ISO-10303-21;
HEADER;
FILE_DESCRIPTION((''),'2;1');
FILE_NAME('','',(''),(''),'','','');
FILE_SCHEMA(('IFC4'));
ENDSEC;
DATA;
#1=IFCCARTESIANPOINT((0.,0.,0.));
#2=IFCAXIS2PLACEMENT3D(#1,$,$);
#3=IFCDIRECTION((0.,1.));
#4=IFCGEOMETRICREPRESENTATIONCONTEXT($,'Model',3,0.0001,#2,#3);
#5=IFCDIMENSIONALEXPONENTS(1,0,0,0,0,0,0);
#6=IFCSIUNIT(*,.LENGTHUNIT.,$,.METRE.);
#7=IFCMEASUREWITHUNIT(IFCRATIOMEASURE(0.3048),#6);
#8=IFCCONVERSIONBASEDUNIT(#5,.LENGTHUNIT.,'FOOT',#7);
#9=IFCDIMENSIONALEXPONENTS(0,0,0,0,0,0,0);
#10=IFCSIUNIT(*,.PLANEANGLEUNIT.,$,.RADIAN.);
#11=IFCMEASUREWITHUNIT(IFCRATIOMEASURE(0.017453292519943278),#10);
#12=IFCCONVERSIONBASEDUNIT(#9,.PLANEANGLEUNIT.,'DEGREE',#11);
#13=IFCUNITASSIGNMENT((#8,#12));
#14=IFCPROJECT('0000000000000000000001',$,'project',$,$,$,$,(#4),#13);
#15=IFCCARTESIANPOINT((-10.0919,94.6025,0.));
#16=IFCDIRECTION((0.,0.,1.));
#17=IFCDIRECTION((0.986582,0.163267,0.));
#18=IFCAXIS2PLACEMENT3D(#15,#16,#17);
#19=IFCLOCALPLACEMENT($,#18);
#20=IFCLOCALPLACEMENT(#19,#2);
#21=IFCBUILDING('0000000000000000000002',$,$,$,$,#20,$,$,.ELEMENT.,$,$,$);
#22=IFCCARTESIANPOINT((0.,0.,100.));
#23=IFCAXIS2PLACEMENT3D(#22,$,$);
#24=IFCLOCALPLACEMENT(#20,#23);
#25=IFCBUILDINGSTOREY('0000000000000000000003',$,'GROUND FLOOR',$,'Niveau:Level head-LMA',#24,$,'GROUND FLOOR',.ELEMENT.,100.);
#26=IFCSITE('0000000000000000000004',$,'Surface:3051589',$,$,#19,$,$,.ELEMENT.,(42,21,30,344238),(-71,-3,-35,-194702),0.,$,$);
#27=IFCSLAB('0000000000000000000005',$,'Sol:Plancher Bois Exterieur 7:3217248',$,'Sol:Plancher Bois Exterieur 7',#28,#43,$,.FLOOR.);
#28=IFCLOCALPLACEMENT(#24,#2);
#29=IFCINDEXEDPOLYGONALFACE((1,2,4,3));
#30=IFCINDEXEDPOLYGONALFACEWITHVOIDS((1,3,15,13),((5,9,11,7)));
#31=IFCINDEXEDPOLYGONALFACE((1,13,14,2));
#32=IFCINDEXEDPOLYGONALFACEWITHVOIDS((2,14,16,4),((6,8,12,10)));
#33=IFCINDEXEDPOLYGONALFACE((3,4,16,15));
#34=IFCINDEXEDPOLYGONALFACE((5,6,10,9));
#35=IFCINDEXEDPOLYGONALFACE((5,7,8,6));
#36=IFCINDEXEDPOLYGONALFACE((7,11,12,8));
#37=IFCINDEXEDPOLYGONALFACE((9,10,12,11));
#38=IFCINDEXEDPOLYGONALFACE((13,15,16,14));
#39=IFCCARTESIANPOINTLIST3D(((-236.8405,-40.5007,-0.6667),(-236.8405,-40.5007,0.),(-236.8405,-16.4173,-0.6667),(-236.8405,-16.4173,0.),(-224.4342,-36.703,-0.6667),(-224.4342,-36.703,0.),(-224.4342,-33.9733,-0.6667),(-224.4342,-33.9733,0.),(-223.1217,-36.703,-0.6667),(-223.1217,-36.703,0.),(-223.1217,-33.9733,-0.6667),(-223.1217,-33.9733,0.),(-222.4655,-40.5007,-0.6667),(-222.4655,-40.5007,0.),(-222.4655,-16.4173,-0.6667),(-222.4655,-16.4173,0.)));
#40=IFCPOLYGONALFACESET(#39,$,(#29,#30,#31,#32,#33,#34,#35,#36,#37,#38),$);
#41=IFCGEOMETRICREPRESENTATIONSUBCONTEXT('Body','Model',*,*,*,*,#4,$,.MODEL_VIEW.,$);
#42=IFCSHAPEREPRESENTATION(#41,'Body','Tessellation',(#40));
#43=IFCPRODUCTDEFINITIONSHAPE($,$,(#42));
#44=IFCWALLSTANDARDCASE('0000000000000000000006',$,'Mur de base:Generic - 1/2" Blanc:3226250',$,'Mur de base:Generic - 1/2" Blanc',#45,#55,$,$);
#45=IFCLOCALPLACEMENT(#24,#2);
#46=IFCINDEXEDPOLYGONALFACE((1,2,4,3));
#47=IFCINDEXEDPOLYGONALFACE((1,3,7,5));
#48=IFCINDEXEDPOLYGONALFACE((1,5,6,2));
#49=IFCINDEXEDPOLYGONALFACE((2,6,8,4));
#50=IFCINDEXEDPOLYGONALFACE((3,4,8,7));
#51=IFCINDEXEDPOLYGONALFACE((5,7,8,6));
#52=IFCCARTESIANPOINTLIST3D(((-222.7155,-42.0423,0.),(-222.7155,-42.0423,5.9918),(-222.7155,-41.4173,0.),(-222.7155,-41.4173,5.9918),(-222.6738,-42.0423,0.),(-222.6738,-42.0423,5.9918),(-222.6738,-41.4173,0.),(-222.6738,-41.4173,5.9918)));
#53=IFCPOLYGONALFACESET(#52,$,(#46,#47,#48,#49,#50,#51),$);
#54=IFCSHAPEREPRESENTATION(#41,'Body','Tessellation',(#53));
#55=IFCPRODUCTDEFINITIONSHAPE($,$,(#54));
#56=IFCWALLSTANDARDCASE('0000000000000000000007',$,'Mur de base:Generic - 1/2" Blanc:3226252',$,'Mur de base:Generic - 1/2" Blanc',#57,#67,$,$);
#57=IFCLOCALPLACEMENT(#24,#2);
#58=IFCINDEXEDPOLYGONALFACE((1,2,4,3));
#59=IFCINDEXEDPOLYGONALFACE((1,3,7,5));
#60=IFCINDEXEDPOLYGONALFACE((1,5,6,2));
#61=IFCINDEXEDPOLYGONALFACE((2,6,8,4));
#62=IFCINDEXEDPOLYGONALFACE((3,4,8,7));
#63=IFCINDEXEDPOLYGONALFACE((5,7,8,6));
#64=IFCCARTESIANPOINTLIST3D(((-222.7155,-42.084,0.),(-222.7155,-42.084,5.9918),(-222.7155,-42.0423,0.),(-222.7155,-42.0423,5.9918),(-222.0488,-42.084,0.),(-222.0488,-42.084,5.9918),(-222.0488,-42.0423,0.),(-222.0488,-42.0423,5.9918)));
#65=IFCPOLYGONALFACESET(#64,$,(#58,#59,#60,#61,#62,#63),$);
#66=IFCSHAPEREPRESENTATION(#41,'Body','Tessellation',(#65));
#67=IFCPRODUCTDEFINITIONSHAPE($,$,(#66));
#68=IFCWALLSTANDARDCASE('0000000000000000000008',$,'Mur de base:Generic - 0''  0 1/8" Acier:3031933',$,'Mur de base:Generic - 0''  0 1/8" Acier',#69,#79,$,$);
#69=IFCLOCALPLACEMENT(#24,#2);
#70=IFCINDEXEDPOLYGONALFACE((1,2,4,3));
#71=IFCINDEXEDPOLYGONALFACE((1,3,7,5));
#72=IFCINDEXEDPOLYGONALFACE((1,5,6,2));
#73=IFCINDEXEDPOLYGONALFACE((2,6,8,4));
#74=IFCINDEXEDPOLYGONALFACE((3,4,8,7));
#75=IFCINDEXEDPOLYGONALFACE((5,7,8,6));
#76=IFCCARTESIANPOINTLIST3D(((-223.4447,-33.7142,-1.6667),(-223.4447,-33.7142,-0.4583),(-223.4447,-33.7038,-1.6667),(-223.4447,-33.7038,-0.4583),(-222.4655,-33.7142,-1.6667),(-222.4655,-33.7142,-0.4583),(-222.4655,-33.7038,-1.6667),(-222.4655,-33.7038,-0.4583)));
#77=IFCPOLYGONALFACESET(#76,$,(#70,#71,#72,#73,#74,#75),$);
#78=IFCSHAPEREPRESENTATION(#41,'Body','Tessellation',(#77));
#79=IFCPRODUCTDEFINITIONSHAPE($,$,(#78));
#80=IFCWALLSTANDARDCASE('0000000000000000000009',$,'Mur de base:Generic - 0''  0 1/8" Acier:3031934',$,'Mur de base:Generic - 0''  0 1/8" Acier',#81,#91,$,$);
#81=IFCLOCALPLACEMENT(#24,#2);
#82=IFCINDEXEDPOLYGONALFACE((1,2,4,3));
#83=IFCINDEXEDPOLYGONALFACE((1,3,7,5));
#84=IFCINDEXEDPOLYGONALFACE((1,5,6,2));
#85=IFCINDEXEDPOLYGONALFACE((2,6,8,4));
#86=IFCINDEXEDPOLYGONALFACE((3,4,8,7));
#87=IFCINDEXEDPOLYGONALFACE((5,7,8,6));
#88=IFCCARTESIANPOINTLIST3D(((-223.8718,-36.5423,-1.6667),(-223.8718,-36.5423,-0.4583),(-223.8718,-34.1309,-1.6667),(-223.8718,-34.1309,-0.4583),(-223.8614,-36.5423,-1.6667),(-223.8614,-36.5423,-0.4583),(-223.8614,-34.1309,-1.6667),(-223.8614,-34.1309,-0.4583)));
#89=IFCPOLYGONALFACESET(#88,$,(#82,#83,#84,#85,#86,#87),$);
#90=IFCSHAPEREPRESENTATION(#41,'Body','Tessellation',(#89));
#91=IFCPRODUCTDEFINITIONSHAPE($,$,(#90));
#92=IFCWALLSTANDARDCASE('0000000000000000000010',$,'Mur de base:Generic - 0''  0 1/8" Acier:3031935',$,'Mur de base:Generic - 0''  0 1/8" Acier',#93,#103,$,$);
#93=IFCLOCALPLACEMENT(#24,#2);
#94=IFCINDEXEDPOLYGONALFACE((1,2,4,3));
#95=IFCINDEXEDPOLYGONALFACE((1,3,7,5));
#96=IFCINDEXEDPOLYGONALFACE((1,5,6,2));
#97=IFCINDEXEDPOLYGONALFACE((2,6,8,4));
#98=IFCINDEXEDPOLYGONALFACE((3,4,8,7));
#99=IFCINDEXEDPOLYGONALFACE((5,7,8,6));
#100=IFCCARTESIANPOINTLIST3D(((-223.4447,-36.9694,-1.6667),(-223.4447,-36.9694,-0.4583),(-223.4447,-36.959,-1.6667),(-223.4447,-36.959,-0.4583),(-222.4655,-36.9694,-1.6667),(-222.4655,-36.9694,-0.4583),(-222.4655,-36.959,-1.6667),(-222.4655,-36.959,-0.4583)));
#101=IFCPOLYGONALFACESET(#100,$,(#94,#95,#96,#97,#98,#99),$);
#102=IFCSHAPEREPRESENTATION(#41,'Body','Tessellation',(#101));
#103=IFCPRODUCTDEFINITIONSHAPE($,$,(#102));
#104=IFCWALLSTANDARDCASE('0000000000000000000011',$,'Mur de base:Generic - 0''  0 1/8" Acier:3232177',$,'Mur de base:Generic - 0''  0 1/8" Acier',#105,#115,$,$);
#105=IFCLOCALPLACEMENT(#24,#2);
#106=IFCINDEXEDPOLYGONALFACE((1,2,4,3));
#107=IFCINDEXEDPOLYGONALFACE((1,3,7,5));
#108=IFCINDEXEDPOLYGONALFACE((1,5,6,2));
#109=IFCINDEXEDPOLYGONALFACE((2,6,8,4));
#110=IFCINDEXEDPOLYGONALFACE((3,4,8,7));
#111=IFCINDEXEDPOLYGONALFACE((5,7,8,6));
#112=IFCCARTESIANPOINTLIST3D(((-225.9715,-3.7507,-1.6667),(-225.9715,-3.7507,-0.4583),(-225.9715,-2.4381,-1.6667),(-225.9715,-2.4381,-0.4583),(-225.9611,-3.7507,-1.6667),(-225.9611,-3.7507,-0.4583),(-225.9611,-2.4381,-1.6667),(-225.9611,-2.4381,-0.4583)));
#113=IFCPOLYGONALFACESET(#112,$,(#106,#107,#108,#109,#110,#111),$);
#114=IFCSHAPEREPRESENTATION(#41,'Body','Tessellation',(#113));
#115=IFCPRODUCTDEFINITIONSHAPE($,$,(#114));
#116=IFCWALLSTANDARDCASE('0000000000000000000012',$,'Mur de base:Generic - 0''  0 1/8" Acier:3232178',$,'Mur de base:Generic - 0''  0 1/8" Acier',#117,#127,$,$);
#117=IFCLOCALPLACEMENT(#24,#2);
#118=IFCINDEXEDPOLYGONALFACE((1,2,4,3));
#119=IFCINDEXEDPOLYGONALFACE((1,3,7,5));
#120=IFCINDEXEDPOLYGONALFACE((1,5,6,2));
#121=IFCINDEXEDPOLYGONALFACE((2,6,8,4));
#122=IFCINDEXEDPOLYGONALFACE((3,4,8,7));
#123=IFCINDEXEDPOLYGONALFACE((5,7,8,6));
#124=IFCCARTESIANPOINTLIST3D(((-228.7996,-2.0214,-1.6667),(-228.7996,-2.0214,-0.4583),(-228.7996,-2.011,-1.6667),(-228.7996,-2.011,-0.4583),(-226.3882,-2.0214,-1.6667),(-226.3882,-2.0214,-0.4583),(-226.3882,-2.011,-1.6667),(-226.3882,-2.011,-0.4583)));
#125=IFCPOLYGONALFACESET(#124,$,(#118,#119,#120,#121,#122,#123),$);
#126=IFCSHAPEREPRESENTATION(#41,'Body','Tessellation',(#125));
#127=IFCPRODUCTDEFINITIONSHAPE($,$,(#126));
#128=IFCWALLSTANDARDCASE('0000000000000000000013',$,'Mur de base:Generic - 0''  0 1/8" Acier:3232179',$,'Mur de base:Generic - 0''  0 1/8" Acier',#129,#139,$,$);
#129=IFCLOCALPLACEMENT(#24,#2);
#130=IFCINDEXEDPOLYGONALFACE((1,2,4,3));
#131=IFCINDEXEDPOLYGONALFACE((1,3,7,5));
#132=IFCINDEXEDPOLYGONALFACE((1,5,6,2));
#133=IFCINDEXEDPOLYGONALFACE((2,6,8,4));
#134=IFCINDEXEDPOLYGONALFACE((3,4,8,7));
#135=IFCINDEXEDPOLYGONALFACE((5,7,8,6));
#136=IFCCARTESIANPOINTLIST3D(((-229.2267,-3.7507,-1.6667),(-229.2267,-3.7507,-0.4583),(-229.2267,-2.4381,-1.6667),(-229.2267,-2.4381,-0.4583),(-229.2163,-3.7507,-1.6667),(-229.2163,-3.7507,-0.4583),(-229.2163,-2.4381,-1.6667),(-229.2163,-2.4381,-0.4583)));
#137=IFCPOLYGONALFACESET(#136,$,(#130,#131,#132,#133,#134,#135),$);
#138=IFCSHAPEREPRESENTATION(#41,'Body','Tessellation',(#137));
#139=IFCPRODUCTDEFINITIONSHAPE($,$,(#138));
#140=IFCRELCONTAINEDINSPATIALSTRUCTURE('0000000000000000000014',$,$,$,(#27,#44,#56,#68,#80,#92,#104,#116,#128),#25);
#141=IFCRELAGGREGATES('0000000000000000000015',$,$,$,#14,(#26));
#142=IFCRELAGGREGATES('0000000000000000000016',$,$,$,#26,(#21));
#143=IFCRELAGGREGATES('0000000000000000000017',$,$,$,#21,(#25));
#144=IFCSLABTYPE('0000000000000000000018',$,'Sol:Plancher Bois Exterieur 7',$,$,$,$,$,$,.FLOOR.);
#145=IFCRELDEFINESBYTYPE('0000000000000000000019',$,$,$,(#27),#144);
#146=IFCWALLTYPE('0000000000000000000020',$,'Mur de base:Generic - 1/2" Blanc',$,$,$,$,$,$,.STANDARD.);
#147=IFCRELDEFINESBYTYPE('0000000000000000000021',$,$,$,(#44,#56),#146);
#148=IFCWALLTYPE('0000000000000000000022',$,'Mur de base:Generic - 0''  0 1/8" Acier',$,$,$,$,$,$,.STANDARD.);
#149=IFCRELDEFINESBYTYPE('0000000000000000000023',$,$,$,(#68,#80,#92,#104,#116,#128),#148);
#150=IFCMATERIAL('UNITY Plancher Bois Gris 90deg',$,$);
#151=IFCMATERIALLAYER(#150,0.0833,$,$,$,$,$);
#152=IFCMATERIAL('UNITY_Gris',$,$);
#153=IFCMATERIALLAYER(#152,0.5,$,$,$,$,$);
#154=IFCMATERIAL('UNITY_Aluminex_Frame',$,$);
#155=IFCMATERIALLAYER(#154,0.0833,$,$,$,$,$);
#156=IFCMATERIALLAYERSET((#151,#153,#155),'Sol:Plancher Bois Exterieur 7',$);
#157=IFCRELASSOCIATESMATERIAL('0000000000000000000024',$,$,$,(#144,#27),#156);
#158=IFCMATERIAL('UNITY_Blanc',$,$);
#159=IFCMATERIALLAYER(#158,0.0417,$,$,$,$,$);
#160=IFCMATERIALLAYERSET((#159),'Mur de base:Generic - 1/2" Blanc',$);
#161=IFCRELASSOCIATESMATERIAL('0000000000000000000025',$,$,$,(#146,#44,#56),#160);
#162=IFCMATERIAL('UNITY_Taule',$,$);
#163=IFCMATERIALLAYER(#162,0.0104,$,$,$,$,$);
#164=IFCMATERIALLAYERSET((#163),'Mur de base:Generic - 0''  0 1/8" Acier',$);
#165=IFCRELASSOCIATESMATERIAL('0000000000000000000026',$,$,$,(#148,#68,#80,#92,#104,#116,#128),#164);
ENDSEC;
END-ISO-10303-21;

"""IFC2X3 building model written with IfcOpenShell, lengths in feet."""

from ifc_helpers import new_model, entity, si_unit, converted_unit, direction, frame, frame_2d, origin, origin_2d_with_axis, place, context, subcontext, project, spatial, polyline, rectangle, extrude, clip, bounded_halfspace, material, layer, layer_set, layer_usage, type_object, element, save


model = new_model("IFC2X3")

# Units and contexts
model_context = context("Model", 3, precision=0.0001, world=origin(), true_north=direction((0.0, 1.0)))
body_context = subcontext(model_context, "Body", "Model", "MODEL_VIEW")
ifc_project = project(units=[converted_unit("LENGTHUNIT", "FOOT", entity("IfcRatioMeasure", 0.3048), si_unit("LENGTHUNIT", "METRE"), dimensions=[1, 0, 0, 0, 0, 0, 0]), converted_unit("PLANEANGLEUNIT", "DEGREE", entity("IfcRatioMeasure", 0.017453292519943278), si_unit("PLANEANGLEUNIT", "RADIAN"), dimensions=[0, 0, 0, 0, 0, 0, 0])], contexts=[model_context])

# Site, building, storey
site_placement = place(None, frame((-10.0919, 94.6025, 0.0), z_axis=(0.0, 0.0, 1.0), x_axis=(0.986582, 0.163267, 0.0)))
site = spatial("IfcSite", under=ifc_project, at=site_placement, Name="Surface:3051589", CompositionType="ELEMENT", RefLatitude=(42, 21, 30, 344238), RefLongitude=(-71, -3, -35, -194702), RefElevation=0.0)
building_placement = place(site_placement, origin())
building = spatial("IfcBuilding", under=site, at=building_placement, CompositionType="ELEMENT")
storey_placement = place(building_placement, frame((0.0, 0.0, 100.0)))
storey = spatial("IfcBuildingStorey", under=building, at=storey_placement, Name="GROUND FLOOR", ObjectType="Niveau:Level head-LMA", LongName="GROUND FLOOR", CompositionType="ELEMENT", Elevation=100.0)

# Shared definitions
ifc_material_1 = material(Name="UNITY_Aluminex_Frame")

# Slab, opening
ifc_material_2 = material(Name="UNITY Plancher Bois Gris 90deg")
ifc_layer_1 = layer(ifc_material_2, 0.0833)
ifc_material_3 = material(Name="UNITY_Gris")
ifc_layer_2 = layer(ifc_material_3, 0.5)
ifc_layer_3 = layer(ifc_material_1, 0.0833)
ifc_layer_set_1 = layer_set([ifc_layer_1, ifc_layer_2, ifc_layer_3], Name="Sol:Plancher Bois Exterieur 7")
ifc_layer_usage_1 = layer_usage(ifc_layer_set_1, "AXIS3", "POSITIVE", 0.0)
slab_type = type_object("IfcSlabType", Name="Sol:Plancher Bois Exterieur 7", PredefinedType="FLOOR", material=ifc_layer_set_1)
slab_placement = place(storey_placement, frame((-236.8405, -40.5007, -0.6667)))
slab = element("IfcSlab", 1, at=slab_placement, inside=storey, type_object=slab_type, material=ifc_layer_usage_1, Name="Sol:Plancher Bois Exterieur 7:3217248", ObjectType="Sol:Plancher Bois Exterieur 7", PredefinedType="FLOOR", context=body_context, shape_type="SweptSolid", body=[
    extrude(rectangle(XDim=24.0833, YDim=14.375, at=frame_2d((0.0, 0.0), x_axis=(0.0, 1.0))), frame((7.1875, 12.0417, 0.6667), z_axis=(0.0, 0.0, -1.0), x_axis=(-1.0, 0.0, 0.0)), (0.0, 0.0, 1.0), 0.6667),
])
opening_1_placement = place(slab_placement, frame((13.0625, 5.1625, 0.6667)))
element("IfcOpeningElement", 2, at=opening_1_placement, cuts=slab, ObjectType="Opening", context=body_context, shape_type="SweptSolid", body=[
    extrude(rectangle(XDim=2.7297, YDim=1.3125, at=origin_2d_with_axis()), frame((0.0, 0.0, 0.0), z_axis=(0.0, 0.0, -1.0), x_axis=(0.0, 1.0, 0.0)), (0.0, 0.0, 1.0), 0.6667),
])

# Walls
ifc_material_4 = material(Name="UNITY_Blanc")
ifc_layer_4 = layer(ifc_material_4, 0.0417)
ifc_layer_set_2 = layer_set([ifc_layer_4], Name="Mur de base:Generic - 1/2\" Blanc")
ifc_layer_usage_2 = layer_usage(ifc_layer_set_2, "AXIS2", "POSITIVE", -0.0208)
wall_type_1 = type_object("IfcWallType", Name="Mur de base:Generic - 1/2\" Blanc", PredefinedType="STANDARD", material=ifc_layer_set_2)
wall_1_placement = place(storey_placement, frame((-222.6947, -41.4173, 0.0), z_axis=(0.0, 0.0, 1.0), x_axis=(0.0, -1.0, 0.0)))
element("IfcWallStandardCase", 3, at=wall_1_placement, inside=storey, type_object=wall_type_1, material=ifc_layer_usage_2, Name="Mur de base:Generic - 1/2\" Blanc:3226250", ObjectType="Mur de base:Generic - 1/2\" Blanc", context=body_context, shape_type="Clipping", body=[
    clip(extrude(rectangle(XDim=0.625, YDim=0.0417, at=frame_2d((0.3125, 0.0), x_axis=(-1.0, 0.0))), origin(), (0.0, 0.0, 1.0), 5.9918), bounded_halfspace(frame((0.0, -0.0208, 9.9189), z_axis=(0.0, -0.721387, 0.692532), x_axis=(1.0, 0.0, 0.0)), False, frame((0.0, -0.0208, 9.9189)), polyline([(0.0, 0.0), (0.625, 0.0), (0.625, 0.0417), (0.0, 0.0417), (0.0, 0.0)]))),
])
ifc_layer_usage_3 = layer_usage(ifc_layer_set_2, "AXIS2", "POSITIVE", -0.0208)
wall_2_placement = place(storey_placement, frame((-222.7155, -42.0632, 0.0)))
element("IfcWallStandardCase", 4, at=wall_2_placement, inside=storey, type_object=wall_type_1, material=ifc_layer_usage_3, Name="Mur de base:Generic - 1/2\" Blanc:3226252", ObjectType="Mur de base:Generic - 1/2\" Blanc", context=body_context, shape_type="Clipping", body=[
    clip(extrude(rectangle(XDim=0.6667, YDim=0.0417, at=frame_2d((0.3333, 0.0), x_axis=(-1.0, 0.0))), origin(), (0.0, 0.0, 1.0), 5.9918), bounded_halfspace(frame((0.0, -0.0208, 9.9189), z_axis=(-0.721387, 0.0, 0.692532), x_axis=(0.0, -1.0, 0.0)), False, frame((0.0, -0.0208, 9.9189)), polyline([(0.0, 0.0), (0.6667, 0.0), (0.6667, 0.0417), (0.0417, 0.0417), (0.0, 0.0417), (0.0, 0.0)]))),
])

# Walls
ifc_material_5 = material(Name="UNITY_Taule")
ifc_layer_5 = layer(ifc_material_5, 0.0104)
ifc_layer_set_3 = layer_set([ifc_layer_5], Name="Mur de base:Generic - 0'  0 1/8\" Acier")
wall_type_2 = type_object("IfcWallType", Name="Mur de base:Generic - 0'  0 1/8\" Acier", PredefinedType="STANDARD", material=ifc_layer_set_3)
ifc_layer_usage_4 = layer_usage(ifc_layer_set_3, "AXIS2", "NEGATIVE", 0.0052)
wall_3_placement = place(storey_placement, frame((-222.4655, -33.709, -1.6667), z_axis=(0.0, 0.0, 1.0), x_axis=(-1.0, 0.0, 0.0)))
element("IfcWallStandardCase", 5, at=wall_3_placement, inside=storey, type_object=wall_type_2, material=ifc_layer_usage_4, Name="Mur de base:Generic - 0'  0 1/8\" Acier:3031933", ObjectType="Mur de base:Generic - 0'  0 1/8\" Acier", context=body_context, shape_type="SweptSolid", body=[
    extrude(rectangle(XDim=0.9792, YDim=0.0104, at=frame_2d((0.4896, 0.0), x_axis=(-1.0, 0.0))), origin(), (0.0, 0.0, 1.0), 1.2083),
])
ifc_layer_usage_5 = layer_usage(ifc_layer_set_3, "AXIS2", "NEGATIVE", 0.0052)
wall_4_placement = place(storey_placement, frame((-223.8666, -34.1309, -1.6667), z_axis=(0.0, 0.0, 1.0), x_axis=(0.0, -1.0, 0.0)))
element("IfcWallStandardCase", 6, at=wall_4_placement, inside=storey, type_object=wall_type_2, material=ifc_layer_usage_5, Name="Mur de base:Generic - 0'  0 1/8\" Acier:3031934", ObjectType="Mur de base:Generic - 0'  0 1/8\" Acier", context=body_context, shape_type="SweptSolid", body=[
    extrude(rectangle(XDim=2.4115, YDim=0.0104, at=frame_2d((1.2057, 0.0), x_axis=(-1.0, 0.0))), origin(), (0.0, 0.0, 1.0), 1.2083),
])
ifc_layer_usage_6 = layer_usage(ifc_layer_set_3, "AXIS2", "POSITIVE", -0.0052)
wall_5_placement = place(storey_placement, frame((-222.4655, -36.9642, -1.6667), z_axis=(0.0, 0.0, 1.0), x_axis=(-1.0, 0.0, 0.0)))
element("IfcWallStandardCase", 7, at=wall_5_placement, inside=storey, type_object=wall_type_2, material=ifc_layer_usage_6, Name="Mur de base:Generic - 0'  0 1/8\" Acier:3031935", ObjectType="Mur de base:Generic - 0'  0 1/8\" Acier", context=body_context, shape_type="SweptSolid", body=[
    extrude(rectangle(XDim=0.9792, YDim=0.0104, at=frame_2d((0.4896, 0.0), x_axis=(-1.0, 0.0))), origin(), (0.0, 0.0, 1.0), 1.2083),
])
ifc_layer_usage_7 = layer_usage(ifc_layer_set_3, "AXIS2", "NEGATIVE", 0.0052)
wall_6_placement = place(storey_placement, frame((-225.9663, -3.7507, -1.6667), z_axis=(0.0, 0.0, 1.0), x_axis=(0.0, 1.0, 0.0)))
element("IfcWallStandardCase", 8, at=wall_6_placement, inside=storey, type_object=wall_type_2, material=ifc_layer_usage_7, Name="Mur de base:Generic - 0'  0 1/8\" Acier:3232177", ObjectType="Mur de base:Generic - 0'  0 1/8\" Acier", context=body_context, shape_type="SweptSolid", body=[
    extrude(rectangle(XDim=1.3126, YDim=0.0104, at=frame_2d((0.6563, 0.0), x_axis=(-1.0, 0.0))), origin(), (0.0, 0.0, 1.0), 1.2083),
])
ifc_layer_usage_8 = layer_usage(ifc_layer_set_3, "AXIS2", "NEGATIVE", 0.0052)
wall_7_placement = place(storey_placement, frame((-226.3882, -2.0162, -1.6667), z_axis=(0.0, 0.0, 1.0), x_axis=(-1.0, 0.0, 0.0)))
element("IfcWallStandardCase", 9, at=wall_7_placement, inside=storey, type_object=wall_type_2, material=ifc_layer_usage_8, Name="Mur de base:Generic - 0'  0 1/8\" Acier:3232178", ObjectType="Mur de base:Generic - 0'  0 1/8\" Acier", context=body_context, shape_type="SweptSolid", body=[
    extrude(rectangle(XDim=2.4115, YDim=0.0104, at=frame_2d((1.2057, 0.0), x_axis=(-1.0, 0.0))), origin(), (0.0, 0.0, 1.0), 1.2083),
])
ifc_layer_usage_9 = layer_usage(ifc_layer_set_3, "AXIS2", "POSITIVE", -0.0052)
wall_8_placement = place(storey_placement, frame((-229.2215, -3.7507, -1.6667), z_axis=(0.0, 0.0, 1.0), x_axis=(0.0, 1.0, 0.0)))
element("IfcWallStandardCase", 10, at=wall_8_placement, inside=storey, type_object=wall_type_2, material=ifc_layer_usage_9, Name="Mur de base:Generic - 0'  0 1/8\" Acier:3232179", ObjectType="Mur de base:Generic - 0'  0 1/8\" Acier", context=body_context, shape_type="SweptSolid", body=[
    extrude(rectangle(XDim=1.3126, YDim=0.0104, at=frame_2d((0.6563, 0.0), x_axis=(-1.0, 0.0))), origin(), (0.0, 0.0, 1.0), 1.2083),
])

save(model, "model.ifc")
